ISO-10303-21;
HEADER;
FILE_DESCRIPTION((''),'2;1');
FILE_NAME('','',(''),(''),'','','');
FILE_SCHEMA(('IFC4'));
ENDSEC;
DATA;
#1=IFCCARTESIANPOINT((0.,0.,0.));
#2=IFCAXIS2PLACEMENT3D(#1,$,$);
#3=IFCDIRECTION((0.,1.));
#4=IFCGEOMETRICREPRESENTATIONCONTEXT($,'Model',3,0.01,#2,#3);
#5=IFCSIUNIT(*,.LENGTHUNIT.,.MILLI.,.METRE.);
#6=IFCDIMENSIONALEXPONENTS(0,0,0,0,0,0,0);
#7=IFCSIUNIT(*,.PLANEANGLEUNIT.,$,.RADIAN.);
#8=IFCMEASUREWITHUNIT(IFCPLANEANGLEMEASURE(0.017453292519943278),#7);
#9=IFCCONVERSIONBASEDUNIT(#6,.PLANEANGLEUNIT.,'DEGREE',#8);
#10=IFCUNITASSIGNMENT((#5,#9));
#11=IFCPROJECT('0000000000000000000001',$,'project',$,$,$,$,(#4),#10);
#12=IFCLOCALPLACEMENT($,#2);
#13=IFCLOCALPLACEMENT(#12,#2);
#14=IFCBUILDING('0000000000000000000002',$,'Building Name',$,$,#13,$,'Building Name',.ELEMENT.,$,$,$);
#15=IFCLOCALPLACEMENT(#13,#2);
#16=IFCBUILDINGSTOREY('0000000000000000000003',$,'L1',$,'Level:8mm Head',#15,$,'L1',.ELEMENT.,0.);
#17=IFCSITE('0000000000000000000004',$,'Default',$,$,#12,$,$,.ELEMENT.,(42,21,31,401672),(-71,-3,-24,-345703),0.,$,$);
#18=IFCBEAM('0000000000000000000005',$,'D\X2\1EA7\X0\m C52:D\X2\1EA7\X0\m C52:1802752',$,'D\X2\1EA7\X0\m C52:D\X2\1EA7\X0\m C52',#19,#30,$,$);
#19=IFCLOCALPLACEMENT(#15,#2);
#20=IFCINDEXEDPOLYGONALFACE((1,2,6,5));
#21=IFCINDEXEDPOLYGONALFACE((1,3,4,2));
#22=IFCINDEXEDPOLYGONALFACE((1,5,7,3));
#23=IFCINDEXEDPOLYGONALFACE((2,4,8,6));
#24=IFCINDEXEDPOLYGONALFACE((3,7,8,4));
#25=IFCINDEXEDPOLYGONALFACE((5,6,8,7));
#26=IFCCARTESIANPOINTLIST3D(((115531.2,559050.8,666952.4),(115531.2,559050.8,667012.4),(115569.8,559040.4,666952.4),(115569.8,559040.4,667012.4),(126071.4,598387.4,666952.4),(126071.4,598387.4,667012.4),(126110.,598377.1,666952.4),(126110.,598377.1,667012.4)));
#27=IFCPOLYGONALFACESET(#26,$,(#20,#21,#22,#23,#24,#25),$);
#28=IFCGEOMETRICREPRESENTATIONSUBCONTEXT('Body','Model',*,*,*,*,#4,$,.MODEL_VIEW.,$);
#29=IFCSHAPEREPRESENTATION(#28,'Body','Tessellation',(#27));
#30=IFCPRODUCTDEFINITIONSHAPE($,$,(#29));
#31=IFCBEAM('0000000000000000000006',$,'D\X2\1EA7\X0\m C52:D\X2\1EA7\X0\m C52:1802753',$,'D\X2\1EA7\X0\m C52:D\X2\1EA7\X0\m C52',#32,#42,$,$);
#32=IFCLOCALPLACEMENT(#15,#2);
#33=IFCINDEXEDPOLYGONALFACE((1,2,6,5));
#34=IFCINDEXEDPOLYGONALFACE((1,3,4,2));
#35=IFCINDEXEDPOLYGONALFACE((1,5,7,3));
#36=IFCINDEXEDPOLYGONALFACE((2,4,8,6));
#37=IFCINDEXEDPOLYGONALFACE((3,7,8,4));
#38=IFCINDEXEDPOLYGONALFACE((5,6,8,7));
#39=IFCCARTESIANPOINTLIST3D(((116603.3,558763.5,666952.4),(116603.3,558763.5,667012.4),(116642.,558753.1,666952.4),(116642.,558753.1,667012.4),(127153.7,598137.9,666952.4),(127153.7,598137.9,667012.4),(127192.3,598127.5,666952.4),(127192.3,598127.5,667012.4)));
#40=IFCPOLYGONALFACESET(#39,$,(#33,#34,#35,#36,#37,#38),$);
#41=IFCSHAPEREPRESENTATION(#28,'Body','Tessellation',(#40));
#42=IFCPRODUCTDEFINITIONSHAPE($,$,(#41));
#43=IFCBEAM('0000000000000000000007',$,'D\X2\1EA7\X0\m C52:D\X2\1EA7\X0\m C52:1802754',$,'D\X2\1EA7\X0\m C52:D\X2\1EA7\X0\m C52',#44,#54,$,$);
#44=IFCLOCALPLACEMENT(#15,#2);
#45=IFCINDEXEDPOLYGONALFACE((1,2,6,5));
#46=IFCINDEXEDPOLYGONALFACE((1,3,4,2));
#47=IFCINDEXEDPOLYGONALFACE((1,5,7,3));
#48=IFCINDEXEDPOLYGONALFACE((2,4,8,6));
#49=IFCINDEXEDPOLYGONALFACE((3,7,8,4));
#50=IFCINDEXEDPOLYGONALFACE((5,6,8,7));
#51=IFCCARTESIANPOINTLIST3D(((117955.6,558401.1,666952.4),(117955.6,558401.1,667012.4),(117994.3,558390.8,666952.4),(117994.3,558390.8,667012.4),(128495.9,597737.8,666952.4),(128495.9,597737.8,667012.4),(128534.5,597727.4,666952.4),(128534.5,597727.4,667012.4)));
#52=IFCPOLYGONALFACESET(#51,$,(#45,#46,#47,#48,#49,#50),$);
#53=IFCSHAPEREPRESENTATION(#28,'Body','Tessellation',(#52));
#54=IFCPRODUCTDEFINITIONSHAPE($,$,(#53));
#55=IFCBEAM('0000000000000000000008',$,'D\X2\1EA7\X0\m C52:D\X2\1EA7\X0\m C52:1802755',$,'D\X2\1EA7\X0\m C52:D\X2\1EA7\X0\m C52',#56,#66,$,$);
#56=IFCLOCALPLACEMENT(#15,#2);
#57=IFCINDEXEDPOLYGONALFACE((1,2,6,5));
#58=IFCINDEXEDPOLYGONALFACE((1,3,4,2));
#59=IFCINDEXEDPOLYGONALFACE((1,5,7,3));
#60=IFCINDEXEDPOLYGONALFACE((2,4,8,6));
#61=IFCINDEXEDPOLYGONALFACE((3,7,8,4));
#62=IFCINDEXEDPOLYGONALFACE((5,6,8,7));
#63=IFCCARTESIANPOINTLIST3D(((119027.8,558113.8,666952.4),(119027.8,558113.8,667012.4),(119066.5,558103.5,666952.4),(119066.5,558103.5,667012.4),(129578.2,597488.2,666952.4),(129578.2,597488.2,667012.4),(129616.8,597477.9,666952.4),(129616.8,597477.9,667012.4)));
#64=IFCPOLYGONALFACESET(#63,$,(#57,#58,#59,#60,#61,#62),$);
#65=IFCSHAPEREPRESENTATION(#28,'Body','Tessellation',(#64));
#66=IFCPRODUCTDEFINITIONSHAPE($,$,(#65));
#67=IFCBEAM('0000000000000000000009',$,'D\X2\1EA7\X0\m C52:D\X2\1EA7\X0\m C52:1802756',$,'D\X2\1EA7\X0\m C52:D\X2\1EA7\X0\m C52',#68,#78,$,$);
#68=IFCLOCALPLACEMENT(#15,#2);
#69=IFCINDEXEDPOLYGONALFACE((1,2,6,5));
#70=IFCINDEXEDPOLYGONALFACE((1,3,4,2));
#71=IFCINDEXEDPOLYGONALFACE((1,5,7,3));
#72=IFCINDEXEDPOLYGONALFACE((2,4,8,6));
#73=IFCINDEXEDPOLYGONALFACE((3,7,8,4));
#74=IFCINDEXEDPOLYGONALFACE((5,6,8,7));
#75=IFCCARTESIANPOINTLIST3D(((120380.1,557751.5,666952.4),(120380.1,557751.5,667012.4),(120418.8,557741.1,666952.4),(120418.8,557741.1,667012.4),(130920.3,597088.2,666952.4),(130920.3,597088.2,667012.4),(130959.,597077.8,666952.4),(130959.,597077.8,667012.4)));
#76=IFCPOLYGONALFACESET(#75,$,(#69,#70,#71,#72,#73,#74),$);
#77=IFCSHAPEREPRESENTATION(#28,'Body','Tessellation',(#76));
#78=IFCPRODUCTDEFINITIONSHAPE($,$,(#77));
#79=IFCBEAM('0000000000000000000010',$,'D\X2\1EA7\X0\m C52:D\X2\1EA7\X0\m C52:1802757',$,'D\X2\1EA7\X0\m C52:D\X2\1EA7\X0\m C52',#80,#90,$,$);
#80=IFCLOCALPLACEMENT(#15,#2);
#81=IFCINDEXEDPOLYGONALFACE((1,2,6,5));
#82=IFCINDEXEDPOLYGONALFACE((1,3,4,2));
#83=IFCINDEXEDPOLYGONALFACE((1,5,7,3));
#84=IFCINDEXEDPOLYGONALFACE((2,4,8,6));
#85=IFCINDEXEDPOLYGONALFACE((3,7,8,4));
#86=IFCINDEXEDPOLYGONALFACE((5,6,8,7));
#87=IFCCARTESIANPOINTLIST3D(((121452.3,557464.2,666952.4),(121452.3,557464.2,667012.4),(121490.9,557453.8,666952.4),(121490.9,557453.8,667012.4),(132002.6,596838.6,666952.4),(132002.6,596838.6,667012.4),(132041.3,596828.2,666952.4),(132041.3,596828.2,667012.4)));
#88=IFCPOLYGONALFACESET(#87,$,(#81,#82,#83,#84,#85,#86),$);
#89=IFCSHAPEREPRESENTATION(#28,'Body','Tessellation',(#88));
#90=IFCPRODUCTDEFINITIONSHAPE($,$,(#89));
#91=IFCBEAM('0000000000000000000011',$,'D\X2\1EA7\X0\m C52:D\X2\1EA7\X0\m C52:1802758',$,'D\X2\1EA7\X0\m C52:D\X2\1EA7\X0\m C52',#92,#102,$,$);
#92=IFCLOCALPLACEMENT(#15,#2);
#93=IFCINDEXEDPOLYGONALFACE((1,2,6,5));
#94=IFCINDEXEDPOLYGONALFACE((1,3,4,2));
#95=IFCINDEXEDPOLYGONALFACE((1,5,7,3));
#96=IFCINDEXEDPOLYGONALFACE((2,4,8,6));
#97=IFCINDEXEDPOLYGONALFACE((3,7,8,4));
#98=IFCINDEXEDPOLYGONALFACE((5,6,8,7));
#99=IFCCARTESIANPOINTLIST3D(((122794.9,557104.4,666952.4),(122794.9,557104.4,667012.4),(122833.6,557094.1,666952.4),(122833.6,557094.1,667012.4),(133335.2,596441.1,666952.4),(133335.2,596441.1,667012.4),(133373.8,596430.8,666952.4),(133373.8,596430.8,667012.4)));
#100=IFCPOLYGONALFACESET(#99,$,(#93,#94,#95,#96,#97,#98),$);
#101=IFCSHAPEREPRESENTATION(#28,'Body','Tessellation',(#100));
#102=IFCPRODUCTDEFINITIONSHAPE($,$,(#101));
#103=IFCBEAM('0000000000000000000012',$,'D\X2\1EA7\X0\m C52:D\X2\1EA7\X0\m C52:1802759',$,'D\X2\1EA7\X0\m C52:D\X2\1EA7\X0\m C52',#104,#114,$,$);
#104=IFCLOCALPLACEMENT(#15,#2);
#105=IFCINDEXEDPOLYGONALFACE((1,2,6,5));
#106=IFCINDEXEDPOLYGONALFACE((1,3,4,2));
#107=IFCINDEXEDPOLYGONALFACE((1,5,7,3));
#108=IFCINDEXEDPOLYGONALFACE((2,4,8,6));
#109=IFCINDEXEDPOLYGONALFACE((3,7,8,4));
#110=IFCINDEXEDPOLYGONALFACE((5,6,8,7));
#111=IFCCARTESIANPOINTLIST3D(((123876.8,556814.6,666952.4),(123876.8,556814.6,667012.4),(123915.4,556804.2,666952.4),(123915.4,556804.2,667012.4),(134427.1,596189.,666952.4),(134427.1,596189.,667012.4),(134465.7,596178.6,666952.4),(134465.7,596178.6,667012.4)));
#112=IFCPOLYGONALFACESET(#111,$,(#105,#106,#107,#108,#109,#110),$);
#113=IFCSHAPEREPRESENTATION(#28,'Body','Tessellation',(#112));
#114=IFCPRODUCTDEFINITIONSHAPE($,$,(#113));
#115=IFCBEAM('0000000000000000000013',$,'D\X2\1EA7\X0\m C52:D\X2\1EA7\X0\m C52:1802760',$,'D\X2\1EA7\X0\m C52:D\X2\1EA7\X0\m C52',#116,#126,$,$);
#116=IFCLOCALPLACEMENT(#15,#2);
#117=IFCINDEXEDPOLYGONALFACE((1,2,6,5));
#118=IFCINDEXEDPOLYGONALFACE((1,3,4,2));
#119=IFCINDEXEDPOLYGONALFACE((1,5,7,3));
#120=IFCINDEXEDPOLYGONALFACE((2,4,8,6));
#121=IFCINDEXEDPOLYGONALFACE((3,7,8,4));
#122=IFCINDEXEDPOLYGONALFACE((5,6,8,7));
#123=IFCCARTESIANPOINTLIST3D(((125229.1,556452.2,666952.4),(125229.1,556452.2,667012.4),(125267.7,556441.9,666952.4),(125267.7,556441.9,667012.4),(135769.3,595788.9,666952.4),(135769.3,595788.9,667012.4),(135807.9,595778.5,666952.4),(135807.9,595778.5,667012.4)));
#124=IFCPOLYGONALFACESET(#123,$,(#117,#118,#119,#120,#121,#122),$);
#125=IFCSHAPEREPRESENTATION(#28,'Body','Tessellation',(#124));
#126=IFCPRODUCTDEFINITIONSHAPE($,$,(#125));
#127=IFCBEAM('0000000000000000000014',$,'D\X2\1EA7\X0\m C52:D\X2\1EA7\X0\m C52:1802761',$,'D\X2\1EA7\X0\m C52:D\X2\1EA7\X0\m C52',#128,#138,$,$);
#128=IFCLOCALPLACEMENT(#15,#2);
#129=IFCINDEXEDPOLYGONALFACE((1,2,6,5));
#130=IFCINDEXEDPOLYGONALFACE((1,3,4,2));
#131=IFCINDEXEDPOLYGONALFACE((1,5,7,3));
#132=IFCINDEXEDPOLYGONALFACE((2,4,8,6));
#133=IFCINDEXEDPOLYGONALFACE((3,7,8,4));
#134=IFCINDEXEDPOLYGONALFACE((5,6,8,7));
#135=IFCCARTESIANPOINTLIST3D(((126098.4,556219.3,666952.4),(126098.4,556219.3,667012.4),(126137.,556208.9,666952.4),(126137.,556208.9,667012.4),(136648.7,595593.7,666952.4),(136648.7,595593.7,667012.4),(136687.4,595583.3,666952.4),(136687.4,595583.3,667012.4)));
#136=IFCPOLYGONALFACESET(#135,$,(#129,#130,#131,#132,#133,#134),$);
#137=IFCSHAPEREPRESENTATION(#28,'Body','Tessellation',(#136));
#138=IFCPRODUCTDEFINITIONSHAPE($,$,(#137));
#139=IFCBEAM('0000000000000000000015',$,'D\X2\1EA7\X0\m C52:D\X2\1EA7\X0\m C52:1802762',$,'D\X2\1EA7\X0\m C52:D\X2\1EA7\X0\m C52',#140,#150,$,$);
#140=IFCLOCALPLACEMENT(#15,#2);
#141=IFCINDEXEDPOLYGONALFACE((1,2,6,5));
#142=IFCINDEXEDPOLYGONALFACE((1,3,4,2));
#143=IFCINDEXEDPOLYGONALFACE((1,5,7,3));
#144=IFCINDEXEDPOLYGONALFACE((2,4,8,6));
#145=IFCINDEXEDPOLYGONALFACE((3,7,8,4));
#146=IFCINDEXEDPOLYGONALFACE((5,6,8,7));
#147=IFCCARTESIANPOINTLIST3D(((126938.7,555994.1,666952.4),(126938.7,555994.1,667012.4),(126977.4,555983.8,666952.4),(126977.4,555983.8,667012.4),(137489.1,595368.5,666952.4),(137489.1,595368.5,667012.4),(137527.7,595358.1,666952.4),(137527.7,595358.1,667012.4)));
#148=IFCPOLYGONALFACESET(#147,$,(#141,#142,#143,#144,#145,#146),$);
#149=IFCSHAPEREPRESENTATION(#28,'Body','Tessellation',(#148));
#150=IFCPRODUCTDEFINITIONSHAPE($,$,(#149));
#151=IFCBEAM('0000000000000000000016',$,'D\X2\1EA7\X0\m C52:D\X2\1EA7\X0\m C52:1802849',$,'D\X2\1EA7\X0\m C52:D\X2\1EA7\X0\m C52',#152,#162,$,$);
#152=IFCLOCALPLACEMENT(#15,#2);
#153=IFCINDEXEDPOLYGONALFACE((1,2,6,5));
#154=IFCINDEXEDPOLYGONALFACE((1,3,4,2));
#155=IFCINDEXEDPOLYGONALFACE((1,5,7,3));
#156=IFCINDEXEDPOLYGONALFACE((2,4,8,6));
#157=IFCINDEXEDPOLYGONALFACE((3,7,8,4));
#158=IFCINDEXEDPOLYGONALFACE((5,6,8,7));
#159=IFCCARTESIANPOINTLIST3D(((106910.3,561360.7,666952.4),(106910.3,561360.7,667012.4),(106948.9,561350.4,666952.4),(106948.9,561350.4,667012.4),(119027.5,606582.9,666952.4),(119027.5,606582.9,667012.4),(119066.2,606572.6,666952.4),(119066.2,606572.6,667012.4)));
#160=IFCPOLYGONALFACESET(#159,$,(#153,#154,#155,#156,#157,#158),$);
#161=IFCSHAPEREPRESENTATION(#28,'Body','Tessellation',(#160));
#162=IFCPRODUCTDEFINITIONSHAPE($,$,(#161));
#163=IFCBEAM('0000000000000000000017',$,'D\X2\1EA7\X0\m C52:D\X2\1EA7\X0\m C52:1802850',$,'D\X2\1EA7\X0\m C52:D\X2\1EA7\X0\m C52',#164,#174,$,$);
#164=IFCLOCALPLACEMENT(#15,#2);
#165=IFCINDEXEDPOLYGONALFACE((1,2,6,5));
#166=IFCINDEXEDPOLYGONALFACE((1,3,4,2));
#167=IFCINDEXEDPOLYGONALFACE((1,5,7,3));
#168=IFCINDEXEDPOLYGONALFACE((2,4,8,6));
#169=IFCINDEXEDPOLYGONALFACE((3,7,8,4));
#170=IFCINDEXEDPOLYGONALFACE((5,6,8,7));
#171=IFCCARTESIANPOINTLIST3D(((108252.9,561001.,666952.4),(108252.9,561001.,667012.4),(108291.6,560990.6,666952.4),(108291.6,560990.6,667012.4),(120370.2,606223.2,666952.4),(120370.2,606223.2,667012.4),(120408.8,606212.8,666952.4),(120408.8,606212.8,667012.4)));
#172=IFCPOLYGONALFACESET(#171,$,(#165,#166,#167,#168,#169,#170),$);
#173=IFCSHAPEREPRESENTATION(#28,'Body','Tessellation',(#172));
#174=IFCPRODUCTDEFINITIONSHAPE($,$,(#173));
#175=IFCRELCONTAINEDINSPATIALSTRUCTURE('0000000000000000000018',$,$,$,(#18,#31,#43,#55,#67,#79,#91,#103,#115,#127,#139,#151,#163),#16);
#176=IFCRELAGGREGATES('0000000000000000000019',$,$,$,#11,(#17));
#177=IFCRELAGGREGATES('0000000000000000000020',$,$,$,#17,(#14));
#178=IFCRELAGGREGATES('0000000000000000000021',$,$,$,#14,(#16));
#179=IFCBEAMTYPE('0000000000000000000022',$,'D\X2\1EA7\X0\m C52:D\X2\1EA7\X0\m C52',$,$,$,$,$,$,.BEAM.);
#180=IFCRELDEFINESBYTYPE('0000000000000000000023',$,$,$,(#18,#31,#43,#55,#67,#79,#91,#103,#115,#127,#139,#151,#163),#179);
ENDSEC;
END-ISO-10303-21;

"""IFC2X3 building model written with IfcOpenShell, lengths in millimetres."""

from ifc_helpers import new_model, entity, si_unit, converted_unit, direction, frame, frame_2d, origin, origin_2d_with_axis, place, context, subcontext, project, spatial, rectangle, extrude, type_object, element, save


model = new_model("IFC2X3")

# Units and contexts
model_context = context("Model", 3, precision=0.01, world=origin(), true_north=direction((0.0, 1.0)))
body_context = subcontext(model_context, "Body", "Model", "MODEL_VIEW")
ifc_project = project(units=[si_unit("LENGTHUNIT", "METRE", prefix="MILLI"), converted_unit("PLANEANGLEUNIT", "DEGREE", entity("IfcPlaneAngleMeasure", 0.017453292519943278), si_unit("PLANEANGLEUNIT", "RADIAN"), dimensions=[0, 0, 0, 0, 0, 0, 0])], contexts=[model_context])

# Site, building, storey
site_placement = place(None, origin())
site = spatial("IfcSite", under=ifc_project, at=site_placement, Name="Default", CompositionType="ELEMENT", RefLatitude=(42, 21, 31, 401672), RefLongitude=(-71, -3, -24, -345703), RefElevation=0.0)
building_placement = place(site_placement, origin())
building = spatial("IfcBuilding", under=site, at=building_placement, Name="Building Name", LongName="Building Name", CompositionType="ELEMENT")
storey_placement = place(building_placement, origin())
storey = spatial("IfcBuildingStorey", under=building, at=storey_placement, Name="L1", ObjectType="Level:8mm Head", LongName="L1", CompositionType="ELEMENT", Elevation=0.0)

# Beams
beam_type = type_object("IfcBeamType", Name="Dầm C52:Dầm C52", PredefinedType="BEAM")
beam_1_placement = place(storey_placement, frame((115550.5, 559045.6, 666862.4), z_axis=(0.0, 0.0, 1.0), x_axis=(0.258819, 0.965926, 0.0)))
element("IfcBeam", 1, at=beam_1_placement, inside=storey, type_object=beam_type, Name="Dầm C52:Dầm C52:1802752", ObjectType="Dầm C52:Dầm C52", context=body_context, shape_type="SweptSolid", body=[
    extrude(rectangle(XDim=60.0, YDim=40.0, at=origin_2d_with_axis()), frame((0.0, 0.0, 120.0), z_axis=(1.0, 0.0, 0.0), x_axis=(0.0, 0.0, -1.0)), (0.0, 0.0, 1.0), 40724.3),
])
beam_2_placement = place(storey_placement, frame((116622.7, 558758.3, 666862.4), z_axis=(0.0, 0.0, 1.0), x_axis=(0.258819, 0.965926, 0.0)))
element("IfcBeam", 2, at=beam_2_placement, inside=storey, type_object=beam_type, Name="Dầm C52:Dầm C52:1802753", ObjectType="Dầm C52:Dầm C52", context=body_context, shape_type="SweptSolid", body=[
    extrude(rectangle(XDim=60.0, YDim=40.0, at=frame_2d((0.0, 0.0), x_axis=(1.0, 0.0))), frame((0.0, 0.0, 120.0), z_axis=(1.0, 0.0, 0.0), x_axis=(0.0, 0.0, -1.0)), (0.0, 0.0, 1.0), 40763.4),
])
beam_3_placement = place(storey_placement, frame((117975.0, 558395.9, 666862.4), z_axis=(0.0, 0.0, 1.0), x_axis=(0.258819, 0.965926, 0.0)))
element("IfcBeam", 3, at=beam_3_placement, inside=storey, type_object=beam_type, Name="Dầm C52:Dầm C52:1802754", ObjectType="Dầm C52:Dầm C52", context=body_context, shape_type="SweptSolid", body=[
    extrude(rectangle(XDim=60.0, YDim=40.0, at=origin_2d_with_axis()), frame((0.0, 0.0, 120.0), z_axis=(1.0, 0.0, 0.0), x_axis=(0.0, 0.0, -1.0)), (0.0, 0.0, 1.0), 40724.3),
])
beam_4_placement = place(storey_placement, frame((119047.1, 558108.7, 666862.4), z_axis=(0.0, 0.0, 1.0), x_axis=(0.258819, 0.965926, 0.0)))
element("IfcBeam", 4, at=beam_4_placement, inside=storey, type_object=beam_type, Name="Dầm C52:Dầm C52:1802755", ObjectType="Dầm C52:Dầm C52", context=body_context, shape_type="SweptSolid", body=[
    extrude(rectangle(XDim=60.0, YDim=40.0, at=frame_2d((0.0, 0.0), x_axis=(1.0, 0.0))), frame((0.0, 0.0, 120.0), z_axis=(1.0, 0.0, 0.0), x_axis=(0.0, 0.0, -1.0)), (0.0, 0.0, 1.0), 40763.4),
])
beam_5_placement = place(storey_placement, frame((120399.4, 557746.3, 666862.4), z_axis=(0.0, 0.0, 1.0), x_axis=(0.258819, 0.965926, 0.0)))
element("IfcBeam", 5, at=beam_5_placement, inside=storey, type_object=beam_type, Name="Dầm C52:Dầm C52:1802756", ObjectType="Dầm C52:Dầm C52", context=body_context, shape_type="SweptSolid", body=[
    extrude(rectangle(XDim=60.0, YDim=40.0, at=frame_2d((0.0, 0.0), x_axis=(1.0, 0.0))), frame((0.0, 0.0, 120.0), z_axis=(1.0, 0.0, 0.0), x_axis=(0.0, 0.0, -1.0)), (0.0, 0.0, 1.0), 40724.3),
])
beam_6_placement = place(storey_placement, frame((121471.6, 557459.0, 666862.4), z_axis=(0.0, 0.0, 1.0), x_axis=(0.258819, 0.965926, 0.0)))
element("IfcBeam", 6, at=beam_6_placement, inside=storey, type_object=beam_type, Name="Dầm C52:Dầm C52:1802757", ObjectType="Dầm C52:Dầm C52", context=body_context, shape_type="SweptSolid", body=[
    extrude(rectangle(XDim=60.0, YDim=40.0, at=origin_2d_with_axis()), frame((0.0, 0.0, 120.0), z_axis=(1.0, 0.0, 0.0), x_axis=(0.0, 0.0, -1.0)), (0.0, 0.0, 1.0), 40763.4),
])
beam_7_placement = place(storey_placement, frame((122814.2, 557099.3, 666862.4), z_axis=(0.0, 0.0, 1.0), x_axis=(0.258819, 0.965926, 0.0)))
element("IfcBeam", 7, at=beam_7_placement, inside=storey, type_object=beam_type, Name="Dầm C52:Dầm C52:1802758", ObjectType="Dầm C52:Dầm C52", context=body_context, shape_type="SweptSolid", body=[
    extrude(rectangle(XDim=60.0, YDim=40.0, at=origin_2d_with_axis()), frame((0.0, 0.0, 120.0), z_axis=(1.0, 0.0, 0.0), x_axis=(0.0, 0.0, -1.0)), (0.0, 0.0, 1.0), 40724.3),
])
beam_8_placement = place(storey_placement, frame((123896.1, 556809.4, 666862.4), z_axis=(0.0, 0.0, 1.0), x_axis=(0.258819, 0.965926, 0.0)))
element("IfcBeam", 8, at=beam_8_placement, inside=storey, type_object=beam_type, Name="Dầm C52:Dầm C52:1802759", ObjectType="Dầm C52:Dầm C52", context=body_context, shape_type="SweptSolid", body=[
    extrude(rectangle(XDim=60.0, YDim=40.0, at=origin_2d_with_axis()), frame((0.0, 0.0, 120.0), z_axis=(1.0, 0.0, 0.0), x_axis=(0.0, 0.0, -1.0)), (0.0, 0.0, 1.0), 40763.4),
])
beam_9_placement = place(storey_placement, frame((125248.4, 556447.0, 666862.4), z_axis=(0.0, 0.0, 1.0), x_axis=(0.258819, 0.965926, 0.0)))
element("IfcBeam", 9, at=beam_9_placement, inside=storey, type_object=beam_type, Name="Dầm C52:Dầm C52:1802760", ObjectType="Dầm C52:Dầm C52", context=body_context, shape_type="SweptSolid", body=[
    extrude(rectangle(XDim=60.0, YDim=40.0, at=origin_2d_with_axis()), frame((0.0, 0.0, 120.0), z_axis=(1.0, 0.0, 0.0), x_axis=(0.0, 0.0, -1.0)), (0.0, 0.0, 1.0), 40724.3),
])
beam_10_placement = place(storey_placement, frame((126117.7, 556214.1, 666862.4), z_axis=(0.0, 0.0, 1.0), x_axis=(0.258819, 0.965926, 0.0)))
element("IfcBeam", 10, at=beam_10_placement, inside=storey, type_object=beam_type, Name="Dầm C52:Dầm C52:1802761", ObjectType="Dầm C52:Dầm C52", context=body_context, shape_type="SweptSolid", body=[
    extrude(rectangle(XDim=60.0, YDim=40.0, at=frame_2d((0.0, 0.0), x_axis=(1.0, 0.0))), frame((0.0, 0.0, 120.0), z_axis=(1.0, 0.0, 0.0), x_axis=(0.0, 0.0, -1.0)), (0.0, 0.0, 1.0), 40763.4),
])
beam_11_placement = place(storey_placement, frame((126958.1, 555988.9, 666862.4), z_axis=(0.0, 0.0, 1.0), x_axis=(0.258819, 0.965926, 0.0)))
element("IfcBeam", 11, at=beam_11_placement, inside=storey, type_object=beam_type, Name="Dầm C52:Dầm C52:1802762", ObjectType="Dầm C52:Dầm C52", context=body_context, shape_type="SweptSolid", body=[
    extrude(rectangle(XDim=60.0, YDim=40.0, at=frame_2d((0.0, 0.0), x_axis=(1.0, 0.0))), frame((0.0, 0.0, 120.0), z_axis=(1.0, 0.0, 0.0), x_axis=(0.0, 0.0, -1.0)), (0.0, 0.0, 1.0), 40763.4),
])
beam_12_placement = place(storey_placement, frame((106929.6, 561355.5, 666862.4), z_axis=(0.0, 0.0, 1.0), x_axis=(0.258819, 0.965926, 0.0)))
element("IfcBeam", 12, at=beam_12_placement, inside=storey, type_object=beam_type, Name="Dầm C52:Dầm C52:1802849", ObjectType="Dầm C52:Dầm C52", context=body_context, shape_type="SweptSolid", body=[
    extrude(rectangle(XDim=60.0, YDim=40.0, at=frame_2d((0.0, 0.0), x_axis=(1.0, 0.0))), frame((0.0, 0.0, 120.0), z_axis=(1.0, 0.0, 0.0), x_axis=(0.0, 0.0, -1.0)), (0.0, 0.0, 1.0), 46817.5),
])
beam_13_placement = place(storey_placement, frame((108272.2, 560995.8, 666862.4), z_axis=(0.0, 0.0, 1.0), x_axis=(0.258819, 0.965926, 0.0)))
element("IfcBeam", 13, at=beam_13_placement, inside=storey, type_object=beam_type, Name="Dầm C52:Dầm C52:1802850", ObjectType="Dầm C52:Dầm C52", context=body_context, shape_type="SweptSolid", body=[
    extrude(rectangle(XDim=60.0, YDim=40.0, at=frame_2d((0.0, 0.0), x_axis=(1.0, 0.0))), frame((0.0, 0.0, 120.0), z_axis=(1.0, 0.0, 0.0), x_axis=(0.0, 0.0, -1.0)), (0.0, 0.0, 1.0), 46817.5),
])

save(model, "model.ifc")
